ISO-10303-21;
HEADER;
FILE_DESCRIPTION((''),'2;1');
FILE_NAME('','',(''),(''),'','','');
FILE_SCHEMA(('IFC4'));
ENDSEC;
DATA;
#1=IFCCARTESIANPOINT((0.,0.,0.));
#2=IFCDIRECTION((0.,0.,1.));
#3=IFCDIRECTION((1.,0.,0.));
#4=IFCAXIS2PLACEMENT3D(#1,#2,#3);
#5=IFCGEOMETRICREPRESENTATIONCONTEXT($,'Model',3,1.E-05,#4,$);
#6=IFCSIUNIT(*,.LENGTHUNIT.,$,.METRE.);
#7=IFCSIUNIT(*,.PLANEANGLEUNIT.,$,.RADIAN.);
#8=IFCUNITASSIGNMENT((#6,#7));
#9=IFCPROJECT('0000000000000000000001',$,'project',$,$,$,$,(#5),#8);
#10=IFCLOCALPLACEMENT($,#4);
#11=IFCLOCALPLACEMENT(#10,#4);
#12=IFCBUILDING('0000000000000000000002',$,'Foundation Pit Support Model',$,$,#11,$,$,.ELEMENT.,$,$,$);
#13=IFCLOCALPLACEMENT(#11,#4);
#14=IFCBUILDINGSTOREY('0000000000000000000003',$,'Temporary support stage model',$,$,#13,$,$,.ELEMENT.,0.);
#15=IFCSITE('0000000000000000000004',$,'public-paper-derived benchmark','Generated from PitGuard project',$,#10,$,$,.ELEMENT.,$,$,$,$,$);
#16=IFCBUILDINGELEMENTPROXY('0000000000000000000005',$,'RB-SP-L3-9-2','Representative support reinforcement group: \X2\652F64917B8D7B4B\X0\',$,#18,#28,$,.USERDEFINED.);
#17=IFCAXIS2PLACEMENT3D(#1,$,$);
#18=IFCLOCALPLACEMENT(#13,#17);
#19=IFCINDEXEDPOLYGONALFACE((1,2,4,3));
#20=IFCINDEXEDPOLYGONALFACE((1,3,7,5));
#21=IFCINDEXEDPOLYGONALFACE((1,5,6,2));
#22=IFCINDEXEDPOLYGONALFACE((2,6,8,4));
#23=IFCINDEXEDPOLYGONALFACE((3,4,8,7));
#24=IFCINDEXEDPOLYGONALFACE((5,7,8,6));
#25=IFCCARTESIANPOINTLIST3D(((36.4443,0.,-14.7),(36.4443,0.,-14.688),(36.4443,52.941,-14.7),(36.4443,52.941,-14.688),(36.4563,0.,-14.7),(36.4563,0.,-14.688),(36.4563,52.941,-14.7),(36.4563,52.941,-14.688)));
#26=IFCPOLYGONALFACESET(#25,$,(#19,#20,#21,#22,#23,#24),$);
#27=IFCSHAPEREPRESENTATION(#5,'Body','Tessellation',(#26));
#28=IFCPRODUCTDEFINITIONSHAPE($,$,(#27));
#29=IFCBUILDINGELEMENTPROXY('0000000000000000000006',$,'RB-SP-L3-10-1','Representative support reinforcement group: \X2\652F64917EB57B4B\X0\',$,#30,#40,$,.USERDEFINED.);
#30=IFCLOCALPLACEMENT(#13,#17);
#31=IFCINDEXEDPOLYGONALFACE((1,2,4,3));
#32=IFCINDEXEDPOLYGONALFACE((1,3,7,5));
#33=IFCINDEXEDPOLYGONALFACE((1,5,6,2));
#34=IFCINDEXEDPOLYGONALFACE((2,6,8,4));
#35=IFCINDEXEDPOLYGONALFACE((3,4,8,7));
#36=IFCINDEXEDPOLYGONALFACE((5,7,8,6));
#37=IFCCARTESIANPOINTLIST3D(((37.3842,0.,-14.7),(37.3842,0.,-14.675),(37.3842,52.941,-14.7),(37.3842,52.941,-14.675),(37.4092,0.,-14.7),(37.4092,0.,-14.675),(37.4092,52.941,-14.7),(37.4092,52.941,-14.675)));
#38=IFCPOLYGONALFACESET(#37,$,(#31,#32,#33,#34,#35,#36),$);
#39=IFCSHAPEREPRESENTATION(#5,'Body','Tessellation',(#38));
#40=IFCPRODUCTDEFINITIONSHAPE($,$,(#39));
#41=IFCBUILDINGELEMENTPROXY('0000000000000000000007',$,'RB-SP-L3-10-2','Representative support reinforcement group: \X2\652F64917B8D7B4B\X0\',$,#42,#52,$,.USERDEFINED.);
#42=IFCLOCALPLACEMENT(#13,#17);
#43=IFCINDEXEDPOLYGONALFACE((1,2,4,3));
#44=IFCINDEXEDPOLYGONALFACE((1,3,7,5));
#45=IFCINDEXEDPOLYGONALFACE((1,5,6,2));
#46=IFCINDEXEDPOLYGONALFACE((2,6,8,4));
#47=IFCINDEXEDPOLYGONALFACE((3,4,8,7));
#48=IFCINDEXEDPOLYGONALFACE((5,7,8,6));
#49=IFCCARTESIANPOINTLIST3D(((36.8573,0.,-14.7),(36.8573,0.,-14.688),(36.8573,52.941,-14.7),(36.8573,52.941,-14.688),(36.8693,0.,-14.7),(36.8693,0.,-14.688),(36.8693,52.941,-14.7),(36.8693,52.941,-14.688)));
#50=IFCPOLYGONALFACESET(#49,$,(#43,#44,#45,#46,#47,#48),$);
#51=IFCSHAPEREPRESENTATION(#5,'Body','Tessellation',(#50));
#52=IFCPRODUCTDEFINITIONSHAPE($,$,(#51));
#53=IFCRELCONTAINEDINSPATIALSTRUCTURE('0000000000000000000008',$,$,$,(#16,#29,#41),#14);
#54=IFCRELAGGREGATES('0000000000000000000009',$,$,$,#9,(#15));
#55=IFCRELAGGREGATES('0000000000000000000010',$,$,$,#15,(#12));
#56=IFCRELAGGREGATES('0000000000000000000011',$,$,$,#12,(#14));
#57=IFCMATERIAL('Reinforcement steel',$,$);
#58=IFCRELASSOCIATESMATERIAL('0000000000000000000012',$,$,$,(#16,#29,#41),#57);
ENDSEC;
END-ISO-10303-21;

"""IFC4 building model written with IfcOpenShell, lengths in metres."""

from ifc_helpers import new_model, si_unit, frame, origin_with_axes, origin_2d, place, context, project, spatial, rectangle, extrude, material, element, save


model = new_model("IFC4")

# Units and contexts
model_context = context("Model", 3, precision=1e-05, world=origin_with_axes())
ifc_project = project(units=[si_unit("LENGTHUNIT", "METRE"), si_unit("PLANEANGLEUNIT", "RADIAN")], contexts=[model_context])

# Site, building, storey
site_placement = place(None, origin_with_axes())
site = spatial("IfcSite", under=ifc_project, at=site_placement, Name="public-paper-derived benchmark", Description="Generated from PitGuard project", CompositionType="ELEMENT")
building_placement = place(site_placement, origin_with_axes())
building = spatial("IfcBuilding", under=site, at=building_placement, Name="Foundation Pit Support Model", CompositionType="ELEMENT")
storey_placement = place(building_placement, origin_with_axes())
storey = spatial("IfcBuildingStorey", under=building, at=storey_placement, Name="Temporary support stage model", CompositionType="ELEMENT", Elevation=0.0)

# Building element proxies
ifc_material_1 = material(Name="Reinforcement steel")
proxy_1_placement = place(storey_placement, frame((36.4503, 26.4705, -14.7), z_axis=(0.0, 0.0, 1.0), x_axis=(0.0, 1.0, 0.0)))
element("IfcBuildingElementProxy", 1, at=proxy_1_placement, inside=storey, material=ifc_material_1, Name="RB-SP-L3-9-2", Description="Representative support reinforcement group: 支撑箍筋", PredefinedType="USERDEFINED", context=model_context, shape_type="SweptSolid", body=[
    extrude(rectangle(XDim=52.941, YDim=0.012, at=origin_2d()), origin_with_axes(), (0.0, 0.0, 1.0), 0.012),
])
proxy_2_placement = place(storey_placement, frame((37.3967, 26.4705, -14.7), z_axis=(0.0, 0.0, 1.0), x_axis=(0.0, 1.0, 0.0)))
element("IfcBuildingElementProxy", 2, at=proxy_2_placement, inside=storey, material=ifc_material_1, Name="RB-SP-L3-10-1", Description="Representative support reinforcement group: 支撑纵筋", PredefinedType="USERDEFINED", context=model_context, shape_type="SweptSolid", body=[
    extrude(rectangle(XDim=52.941, YDim=0.025, at=origin_2d()), origin_with_axes(), (0.0, 0.0, 1.0), 0.025),
])
proxy_3_placement = place(storey_placement, frame((36.8633, 26.4705, -14.7), z_axis=(0.0, 0.0, 1.0), x_axis=(0.0, 1.0, 0.0)))
element("IfcBuildingElementProxy", 3, at=proxy_3_placement, inside=storey, material=ifc_material_1, Name="RB-SP-L3-10-2", Description="Representative support reinforcement group: 支撑箍筋", PredefinedType="USERDEFINED", context=model_context, shape_type="SweptSolid", body=[
    extrude(rectangle(XDim=52.941, YDim=0.012, at=origin_2d()), origin_with_axes(), (0.0, 0.0, 1.0), 0.012),
])

save(model, "model.ifc")
